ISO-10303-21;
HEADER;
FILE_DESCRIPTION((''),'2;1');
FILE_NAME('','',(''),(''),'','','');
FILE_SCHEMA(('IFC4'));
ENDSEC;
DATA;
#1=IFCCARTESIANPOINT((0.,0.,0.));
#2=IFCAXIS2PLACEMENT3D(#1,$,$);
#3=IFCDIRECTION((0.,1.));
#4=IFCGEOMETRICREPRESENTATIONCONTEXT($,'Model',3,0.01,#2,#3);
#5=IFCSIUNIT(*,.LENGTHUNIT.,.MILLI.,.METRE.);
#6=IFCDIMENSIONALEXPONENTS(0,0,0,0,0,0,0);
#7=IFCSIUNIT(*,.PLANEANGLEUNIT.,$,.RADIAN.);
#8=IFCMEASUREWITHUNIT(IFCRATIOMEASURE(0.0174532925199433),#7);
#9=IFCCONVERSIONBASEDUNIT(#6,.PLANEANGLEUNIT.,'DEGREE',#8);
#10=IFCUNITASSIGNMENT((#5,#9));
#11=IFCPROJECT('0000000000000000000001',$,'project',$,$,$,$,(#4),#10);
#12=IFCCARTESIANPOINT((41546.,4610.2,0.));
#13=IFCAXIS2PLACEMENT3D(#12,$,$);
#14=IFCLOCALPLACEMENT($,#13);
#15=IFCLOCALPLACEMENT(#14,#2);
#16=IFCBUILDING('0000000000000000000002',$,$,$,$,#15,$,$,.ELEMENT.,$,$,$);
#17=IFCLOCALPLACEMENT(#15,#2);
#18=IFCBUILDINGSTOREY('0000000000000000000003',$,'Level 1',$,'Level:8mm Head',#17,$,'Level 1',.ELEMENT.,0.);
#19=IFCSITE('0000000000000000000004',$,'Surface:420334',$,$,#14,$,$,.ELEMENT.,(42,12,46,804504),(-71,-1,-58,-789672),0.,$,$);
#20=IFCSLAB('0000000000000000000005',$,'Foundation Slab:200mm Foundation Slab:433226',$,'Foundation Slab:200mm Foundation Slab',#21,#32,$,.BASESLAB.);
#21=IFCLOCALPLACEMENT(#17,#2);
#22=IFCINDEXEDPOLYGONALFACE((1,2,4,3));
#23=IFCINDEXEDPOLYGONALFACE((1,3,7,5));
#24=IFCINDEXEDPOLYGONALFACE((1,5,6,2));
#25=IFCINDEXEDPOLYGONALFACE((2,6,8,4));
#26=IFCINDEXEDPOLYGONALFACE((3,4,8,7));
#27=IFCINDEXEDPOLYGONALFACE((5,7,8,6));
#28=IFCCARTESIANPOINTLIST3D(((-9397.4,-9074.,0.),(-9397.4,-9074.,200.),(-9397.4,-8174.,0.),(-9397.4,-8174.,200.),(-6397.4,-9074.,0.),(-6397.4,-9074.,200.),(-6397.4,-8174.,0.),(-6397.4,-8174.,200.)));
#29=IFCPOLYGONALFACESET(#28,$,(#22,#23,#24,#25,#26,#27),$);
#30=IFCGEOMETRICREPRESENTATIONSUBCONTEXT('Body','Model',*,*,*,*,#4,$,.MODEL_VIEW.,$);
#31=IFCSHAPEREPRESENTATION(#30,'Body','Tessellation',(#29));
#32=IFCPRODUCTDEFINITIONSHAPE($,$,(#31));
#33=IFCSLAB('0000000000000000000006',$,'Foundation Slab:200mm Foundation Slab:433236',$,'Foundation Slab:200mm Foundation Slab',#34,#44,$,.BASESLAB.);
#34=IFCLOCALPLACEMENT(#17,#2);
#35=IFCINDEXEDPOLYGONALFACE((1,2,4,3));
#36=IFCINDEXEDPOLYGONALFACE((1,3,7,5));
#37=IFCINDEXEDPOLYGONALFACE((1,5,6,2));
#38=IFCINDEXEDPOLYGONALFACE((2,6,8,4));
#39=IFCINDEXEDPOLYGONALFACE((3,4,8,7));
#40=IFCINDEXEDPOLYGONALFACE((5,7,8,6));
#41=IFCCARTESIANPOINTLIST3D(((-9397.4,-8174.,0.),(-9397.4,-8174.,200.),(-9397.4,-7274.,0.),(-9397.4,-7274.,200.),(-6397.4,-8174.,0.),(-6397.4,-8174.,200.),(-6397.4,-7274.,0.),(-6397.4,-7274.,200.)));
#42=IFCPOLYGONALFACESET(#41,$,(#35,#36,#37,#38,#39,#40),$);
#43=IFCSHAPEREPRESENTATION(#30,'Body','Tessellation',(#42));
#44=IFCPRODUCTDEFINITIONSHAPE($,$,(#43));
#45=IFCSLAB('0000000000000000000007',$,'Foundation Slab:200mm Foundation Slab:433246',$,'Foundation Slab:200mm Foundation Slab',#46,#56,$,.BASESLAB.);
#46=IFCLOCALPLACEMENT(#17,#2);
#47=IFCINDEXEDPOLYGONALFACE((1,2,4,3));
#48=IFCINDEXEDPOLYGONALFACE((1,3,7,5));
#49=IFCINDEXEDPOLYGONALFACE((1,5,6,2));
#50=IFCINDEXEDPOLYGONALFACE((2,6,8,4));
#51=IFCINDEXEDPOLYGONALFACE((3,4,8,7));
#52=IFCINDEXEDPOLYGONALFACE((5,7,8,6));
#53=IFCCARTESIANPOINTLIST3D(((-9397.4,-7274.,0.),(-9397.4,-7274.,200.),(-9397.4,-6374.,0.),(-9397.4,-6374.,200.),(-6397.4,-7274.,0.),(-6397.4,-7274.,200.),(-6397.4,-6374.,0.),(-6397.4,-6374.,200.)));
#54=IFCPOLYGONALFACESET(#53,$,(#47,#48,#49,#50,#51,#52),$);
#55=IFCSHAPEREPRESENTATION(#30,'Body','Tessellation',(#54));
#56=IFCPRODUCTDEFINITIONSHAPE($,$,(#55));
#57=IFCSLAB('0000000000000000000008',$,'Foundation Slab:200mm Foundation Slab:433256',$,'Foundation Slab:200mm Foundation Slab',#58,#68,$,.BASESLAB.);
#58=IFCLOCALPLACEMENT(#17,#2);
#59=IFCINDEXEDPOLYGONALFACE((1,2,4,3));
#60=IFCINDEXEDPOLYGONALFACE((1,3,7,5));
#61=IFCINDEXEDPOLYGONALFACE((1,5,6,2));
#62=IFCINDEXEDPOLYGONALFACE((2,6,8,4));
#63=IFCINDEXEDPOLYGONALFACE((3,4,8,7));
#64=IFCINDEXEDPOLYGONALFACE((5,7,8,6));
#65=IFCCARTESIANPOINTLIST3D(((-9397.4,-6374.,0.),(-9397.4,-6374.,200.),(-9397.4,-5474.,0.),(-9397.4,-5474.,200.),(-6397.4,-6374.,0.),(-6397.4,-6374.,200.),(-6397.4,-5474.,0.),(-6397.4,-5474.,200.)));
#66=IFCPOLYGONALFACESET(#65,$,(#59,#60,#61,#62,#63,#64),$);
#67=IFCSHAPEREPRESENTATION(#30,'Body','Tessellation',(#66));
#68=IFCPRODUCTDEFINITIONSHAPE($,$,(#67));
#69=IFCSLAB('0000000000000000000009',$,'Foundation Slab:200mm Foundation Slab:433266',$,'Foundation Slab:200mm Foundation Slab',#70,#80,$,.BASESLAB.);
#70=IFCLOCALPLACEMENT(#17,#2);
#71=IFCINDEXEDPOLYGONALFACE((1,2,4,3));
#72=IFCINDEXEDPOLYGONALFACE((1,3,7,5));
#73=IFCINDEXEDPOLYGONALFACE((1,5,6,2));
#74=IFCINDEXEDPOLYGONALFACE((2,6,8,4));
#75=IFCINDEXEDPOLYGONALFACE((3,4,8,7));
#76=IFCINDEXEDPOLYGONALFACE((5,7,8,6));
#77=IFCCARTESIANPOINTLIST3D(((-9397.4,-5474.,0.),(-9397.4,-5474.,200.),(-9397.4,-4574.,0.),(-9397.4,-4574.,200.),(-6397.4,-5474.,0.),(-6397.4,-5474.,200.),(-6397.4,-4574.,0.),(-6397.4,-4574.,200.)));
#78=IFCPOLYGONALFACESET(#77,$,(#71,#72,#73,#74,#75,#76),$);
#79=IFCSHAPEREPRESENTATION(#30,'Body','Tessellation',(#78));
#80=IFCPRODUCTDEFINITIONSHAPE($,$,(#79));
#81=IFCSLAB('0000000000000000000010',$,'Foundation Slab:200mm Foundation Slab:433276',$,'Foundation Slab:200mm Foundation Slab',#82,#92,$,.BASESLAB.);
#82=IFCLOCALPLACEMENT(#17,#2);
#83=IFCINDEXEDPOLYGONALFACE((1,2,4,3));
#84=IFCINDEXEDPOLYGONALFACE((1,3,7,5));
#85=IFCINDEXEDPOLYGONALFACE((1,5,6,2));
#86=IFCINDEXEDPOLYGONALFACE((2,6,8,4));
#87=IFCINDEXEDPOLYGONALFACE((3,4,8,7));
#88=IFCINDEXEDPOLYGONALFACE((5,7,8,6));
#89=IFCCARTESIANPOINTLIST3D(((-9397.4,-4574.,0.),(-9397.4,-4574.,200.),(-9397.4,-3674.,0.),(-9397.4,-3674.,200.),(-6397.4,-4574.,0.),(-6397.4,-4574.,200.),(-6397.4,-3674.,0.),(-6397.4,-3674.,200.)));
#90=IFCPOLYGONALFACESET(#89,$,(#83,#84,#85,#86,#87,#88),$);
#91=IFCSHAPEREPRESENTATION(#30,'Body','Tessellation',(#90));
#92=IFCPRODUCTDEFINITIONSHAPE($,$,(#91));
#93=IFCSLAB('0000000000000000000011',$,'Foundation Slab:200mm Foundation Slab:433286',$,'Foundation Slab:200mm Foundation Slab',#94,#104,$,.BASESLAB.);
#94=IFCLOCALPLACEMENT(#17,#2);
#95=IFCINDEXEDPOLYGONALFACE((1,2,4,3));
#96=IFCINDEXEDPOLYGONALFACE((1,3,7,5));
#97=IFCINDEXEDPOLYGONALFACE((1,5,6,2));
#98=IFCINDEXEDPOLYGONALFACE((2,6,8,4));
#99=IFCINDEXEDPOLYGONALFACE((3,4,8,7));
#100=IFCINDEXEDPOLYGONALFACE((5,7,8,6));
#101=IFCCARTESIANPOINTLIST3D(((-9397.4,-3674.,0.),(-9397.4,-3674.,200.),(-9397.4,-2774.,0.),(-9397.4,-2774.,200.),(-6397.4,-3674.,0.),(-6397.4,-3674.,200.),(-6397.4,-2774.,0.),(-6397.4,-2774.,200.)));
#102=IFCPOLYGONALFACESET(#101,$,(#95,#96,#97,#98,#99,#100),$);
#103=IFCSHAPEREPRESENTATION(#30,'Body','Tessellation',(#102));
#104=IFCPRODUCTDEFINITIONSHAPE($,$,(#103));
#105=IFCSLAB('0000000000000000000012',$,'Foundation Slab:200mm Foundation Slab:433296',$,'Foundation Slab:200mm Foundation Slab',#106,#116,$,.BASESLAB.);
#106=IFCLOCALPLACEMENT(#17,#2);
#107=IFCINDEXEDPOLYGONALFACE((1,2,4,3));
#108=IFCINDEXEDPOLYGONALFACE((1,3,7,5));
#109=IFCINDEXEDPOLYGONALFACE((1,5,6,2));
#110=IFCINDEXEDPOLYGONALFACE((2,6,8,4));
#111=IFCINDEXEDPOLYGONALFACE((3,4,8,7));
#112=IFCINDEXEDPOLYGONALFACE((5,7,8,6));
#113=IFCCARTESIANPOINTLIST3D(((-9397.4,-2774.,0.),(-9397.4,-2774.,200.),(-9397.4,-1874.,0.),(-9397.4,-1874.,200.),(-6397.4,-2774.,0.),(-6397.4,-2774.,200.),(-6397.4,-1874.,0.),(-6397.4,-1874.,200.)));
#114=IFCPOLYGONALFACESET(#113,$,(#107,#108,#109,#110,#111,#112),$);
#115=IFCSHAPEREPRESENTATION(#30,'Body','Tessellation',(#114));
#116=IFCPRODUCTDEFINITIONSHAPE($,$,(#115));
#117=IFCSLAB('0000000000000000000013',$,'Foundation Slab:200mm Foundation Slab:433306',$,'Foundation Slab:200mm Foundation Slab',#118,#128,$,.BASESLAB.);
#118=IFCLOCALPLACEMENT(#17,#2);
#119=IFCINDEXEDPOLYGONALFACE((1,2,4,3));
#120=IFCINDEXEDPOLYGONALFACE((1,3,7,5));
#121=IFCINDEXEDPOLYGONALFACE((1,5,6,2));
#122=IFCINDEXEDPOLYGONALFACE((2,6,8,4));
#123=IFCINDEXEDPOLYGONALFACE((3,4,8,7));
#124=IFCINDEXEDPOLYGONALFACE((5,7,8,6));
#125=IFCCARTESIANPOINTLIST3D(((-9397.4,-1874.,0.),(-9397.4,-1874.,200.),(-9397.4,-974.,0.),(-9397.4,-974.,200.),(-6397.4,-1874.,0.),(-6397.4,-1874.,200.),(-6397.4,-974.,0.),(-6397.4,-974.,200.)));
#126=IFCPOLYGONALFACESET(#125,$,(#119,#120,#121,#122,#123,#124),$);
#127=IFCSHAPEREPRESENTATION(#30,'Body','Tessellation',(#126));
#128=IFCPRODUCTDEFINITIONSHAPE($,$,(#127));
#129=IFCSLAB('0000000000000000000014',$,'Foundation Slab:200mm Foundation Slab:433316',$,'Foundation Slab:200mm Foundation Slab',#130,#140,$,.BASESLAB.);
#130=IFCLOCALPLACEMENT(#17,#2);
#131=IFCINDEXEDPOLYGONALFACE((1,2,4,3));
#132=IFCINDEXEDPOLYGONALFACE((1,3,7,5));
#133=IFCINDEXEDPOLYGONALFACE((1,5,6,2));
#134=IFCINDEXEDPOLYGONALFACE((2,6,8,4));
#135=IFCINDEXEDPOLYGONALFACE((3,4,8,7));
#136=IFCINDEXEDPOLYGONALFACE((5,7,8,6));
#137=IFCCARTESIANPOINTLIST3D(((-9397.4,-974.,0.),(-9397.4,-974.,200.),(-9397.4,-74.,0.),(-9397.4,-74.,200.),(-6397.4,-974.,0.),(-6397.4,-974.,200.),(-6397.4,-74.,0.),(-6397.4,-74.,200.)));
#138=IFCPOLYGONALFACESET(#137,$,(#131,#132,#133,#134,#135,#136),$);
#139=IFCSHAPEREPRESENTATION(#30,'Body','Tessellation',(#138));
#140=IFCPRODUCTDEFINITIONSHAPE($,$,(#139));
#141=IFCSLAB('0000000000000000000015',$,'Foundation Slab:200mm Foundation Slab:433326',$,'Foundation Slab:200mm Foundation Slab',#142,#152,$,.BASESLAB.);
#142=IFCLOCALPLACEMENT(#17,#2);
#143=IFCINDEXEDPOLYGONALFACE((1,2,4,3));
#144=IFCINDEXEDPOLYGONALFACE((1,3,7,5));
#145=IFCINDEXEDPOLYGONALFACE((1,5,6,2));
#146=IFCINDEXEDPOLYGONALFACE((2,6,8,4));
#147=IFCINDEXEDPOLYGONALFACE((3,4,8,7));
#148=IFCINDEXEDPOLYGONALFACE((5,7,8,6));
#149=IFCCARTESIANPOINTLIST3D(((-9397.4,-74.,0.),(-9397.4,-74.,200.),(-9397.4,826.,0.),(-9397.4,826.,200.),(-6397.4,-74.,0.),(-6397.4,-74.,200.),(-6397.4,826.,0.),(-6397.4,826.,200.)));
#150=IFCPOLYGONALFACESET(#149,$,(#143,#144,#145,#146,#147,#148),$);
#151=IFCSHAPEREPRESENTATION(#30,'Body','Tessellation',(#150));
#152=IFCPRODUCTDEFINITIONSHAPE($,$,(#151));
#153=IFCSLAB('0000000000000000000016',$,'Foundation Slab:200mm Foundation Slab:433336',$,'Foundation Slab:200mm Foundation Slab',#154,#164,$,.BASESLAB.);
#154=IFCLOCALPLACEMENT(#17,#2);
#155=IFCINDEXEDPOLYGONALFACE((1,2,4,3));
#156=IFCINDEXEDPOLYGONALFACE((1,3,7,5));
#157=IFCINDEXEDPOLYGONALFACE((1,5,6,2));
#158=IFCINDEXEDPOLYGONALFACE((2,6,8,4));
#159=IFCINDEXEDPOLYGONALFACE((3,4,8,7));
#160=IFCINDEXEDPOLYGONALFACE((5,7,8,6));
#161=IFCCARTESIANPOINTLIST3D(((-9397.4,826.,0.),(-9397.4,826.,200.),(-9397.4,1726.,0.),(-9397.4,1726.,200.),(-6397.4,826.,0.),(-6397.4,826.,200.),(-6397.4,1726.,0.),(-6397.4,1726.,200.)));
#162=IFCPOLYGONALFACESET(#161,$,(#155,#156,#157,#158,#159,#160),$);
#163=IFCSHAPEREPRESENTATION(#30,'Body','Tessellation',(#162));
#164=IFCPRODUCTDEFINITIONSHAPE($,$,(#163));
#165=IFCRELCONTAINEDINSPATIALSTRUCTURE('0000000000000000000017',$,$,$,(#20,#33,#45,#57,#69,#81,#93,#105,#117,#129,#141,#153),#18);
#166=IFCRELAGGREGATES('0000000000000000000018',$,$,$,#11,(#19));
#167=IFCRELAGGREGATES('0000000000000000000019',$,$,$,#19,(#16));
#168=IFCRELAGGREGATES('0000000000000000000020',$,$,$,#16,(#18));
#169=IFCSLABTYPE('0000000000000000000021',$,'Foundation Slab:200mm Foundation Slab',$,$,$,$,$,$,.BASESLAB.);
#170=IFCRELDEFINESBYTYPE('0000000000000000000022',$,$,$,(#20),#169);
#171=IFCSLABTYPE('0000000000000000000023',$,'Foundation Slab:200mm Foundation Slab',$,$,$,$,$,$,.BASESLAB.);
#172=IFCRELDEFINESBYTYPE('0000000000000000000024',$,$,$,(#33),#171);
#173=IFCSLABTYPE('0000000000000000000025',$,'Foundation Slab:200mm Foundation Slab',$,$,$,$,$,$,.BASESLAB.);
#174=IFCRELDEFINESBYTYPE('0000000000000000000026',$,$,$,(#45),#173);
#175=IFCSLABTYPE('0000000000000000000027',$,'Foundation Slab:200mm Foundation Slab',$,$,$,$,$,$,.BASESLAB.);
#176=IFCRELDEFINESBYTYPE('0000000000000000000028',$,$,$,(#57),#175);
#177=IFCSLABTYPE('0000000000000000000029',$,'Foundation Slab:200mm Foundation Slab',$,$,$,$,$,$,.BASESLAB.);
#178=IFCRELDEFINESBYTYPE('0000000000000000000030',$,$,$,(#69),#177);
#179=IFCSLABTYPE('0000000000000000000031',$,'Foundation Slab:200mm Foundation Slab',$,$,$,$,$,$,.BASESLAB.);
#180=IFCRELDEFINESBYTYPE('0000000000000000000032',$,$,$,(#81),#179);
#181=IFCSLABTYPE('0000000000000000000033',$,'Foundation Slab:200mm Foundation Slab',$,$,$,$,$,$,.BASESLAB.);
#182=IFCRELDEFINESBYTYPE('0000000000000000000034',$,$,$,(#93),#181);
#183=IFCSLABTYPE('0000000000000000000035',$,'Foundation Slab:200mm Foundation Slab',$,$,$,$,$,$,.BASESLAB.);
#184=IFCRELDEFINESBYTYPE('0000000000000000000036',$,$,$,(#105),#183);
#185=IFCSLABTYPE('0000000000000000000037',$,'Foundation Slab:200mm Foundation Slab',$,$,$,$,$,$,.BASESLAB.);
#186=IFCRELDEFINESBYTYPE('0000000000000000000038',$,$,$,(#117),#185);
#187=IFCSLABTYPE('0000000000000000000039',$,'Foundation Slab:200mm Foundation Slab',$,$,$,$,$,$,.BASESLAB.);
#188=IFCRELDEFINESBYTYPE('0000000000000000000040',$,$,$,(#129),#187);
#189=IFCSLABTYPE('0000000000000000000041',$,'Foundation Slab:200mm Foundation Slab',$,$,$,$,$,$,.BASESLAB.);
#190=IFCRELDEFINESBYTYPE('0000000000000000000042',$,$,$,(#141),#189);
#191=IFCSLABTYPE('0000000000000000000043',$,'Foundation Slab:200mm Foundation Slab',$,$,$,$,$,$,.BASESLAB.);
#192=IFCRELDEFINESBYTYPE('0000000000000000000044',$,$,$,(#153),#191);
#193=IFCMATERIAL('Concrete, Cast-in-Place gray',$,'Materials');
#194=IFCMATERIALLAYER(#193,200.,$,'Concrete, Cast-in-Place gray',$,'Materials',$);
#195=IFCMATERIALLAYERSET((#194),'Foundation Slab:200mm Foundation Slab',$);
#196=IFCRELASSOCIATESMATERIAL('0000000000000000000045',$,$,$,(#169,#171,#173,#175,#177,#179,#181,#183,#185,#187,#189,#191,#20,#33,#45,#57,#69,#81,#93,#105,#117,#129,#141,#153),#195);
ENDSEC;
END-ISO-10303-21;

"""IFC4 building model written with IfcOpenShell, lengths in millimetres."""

from ifc_helpers import new_model, entity, si_unit, converted_unit, direction, frame, frame_2d, origin, place, context, subcontext, project, spatial, rectangle, extrude, material, layer, layer_set, layer_usage, type_object, element, save


model = new_model("IFC4")

# Units and contexts
model_context = context("Model", 3, precision=0.01, world=origin(), true_north=direction((0.0, 1.0)))
body_context = subcontext(model_context, "Body", "Model", "MODEL_VIEW")
ifc_project = project(units=[si_unit("LENGTHUNIT", "METRE", prefix="MILLI"), converted_unit("PLANEANGLEUNIT", "DEGREE", entity("IfcRatioMeasure", 0.0174532925199433), si_unit("PLANEANGLEUNIT", "RADIAN"), dimensions=[0, 0, 0, 0, 0, 0, 0])], contexts=[model_context])

# Site, building, storey
site_placement = place(None, frame((41546.0, 4610.2, 0.0)))
site = spatial("IfcSite", under=ifc_project, at=site_placement, Name="Surface:420334", CompositionType="ELEMENT", RefLatitude=(42, 12, 46, 804504), RefLongitude=(-71, -1, -58, -789672), RefElevation=0.0)
building_placement = place(site_placement, origin())
building = spatial("IfcBuilding", under=site, at=building_placement, CompositionType="ELEMENT")
storey_placement = place(building_placement, origin())
storey = spatial("IfcBuildingStorey", under=building, at=storey_placement, Name="Level 1", ObjectType="Level:8mm Head", LongName="Level 1", CompositionType="ELEMENT", Elevation=0.0)

# Slabs
ifc_material = material(Name="Concrete, Cast-in-Place gray", Category="Materials")
ifc_layer = layer(ifc_material, 200.0, Name="Concrete, Cast-in-Place gray", Category="Materials")
ifc_layer_set = layer_set([ifc_layer], Name="Foundation Slab:200mm Foundation Slab")
ifc_layer_usage_1 = layer_usage(ifc_layer_set, "AXIS3", "POSITIVE", 0.0)
slab_type_1 = type_object("IfcSlabType", Name="Foundation Slab:200mm Foundation Slab", PredefinedType="BASESLAB", material=ifc_layer_set)
slab_1_placement = place(storey_placement, origin())
element("IfcSlab", 1, at=slab_1_placement, inside=storey, type_object=slab_type_1, material=ifc_layer_usage_1, Name="Foundation Slab:200mm Foundation Slab:433226", ObjectType="Foundation Slab:200mm Foundation Slab", PredefinedType="BASESLAB", context=body_context, shape_type="SweptSolid", body=[
    extrude(rectangle(XDim=900.0, YDim=3000.0, at=frame_2d((0.0, 0.0), x_axis=(1.0, 0.0))), frame((-7897.4, -8624.0, 200.0), z_axis=(0.0, 0.0, -1.0), x_axis=(0.0, 1.0, 0.0)), (0.0, 0.0, 1.0), 200.0),
])
ifc_layer_usage_2 = layer_usage(ifc_layer_set, "AXIS3", "POSITIVE", 0.0)
slab_type_2 = type_object("IfcSlabType", Name="Foundation Slab:200mm Foundation Slab", PredefinedType="BASESLAB", material=ifc_layer_set)
slab_2_placement = place(storey_placement, origin())
element("IfcSlab", 2, at=slab_2_placement, inside=storey, type_object=slab_type_2, material=ifc_layer_usage_2, Name="Foundation Slab:200mm Foundation Slab:433236", ObjectType="Foundation Slab:200mm Foundation Slab", PredefinedType="BASESLAB", context=body_context, shape_type="SweptSolid", body=[
    extrude(rectangle(XDim=900.0, YDim=3000.0, at=frame_2d((0.0, 0.0), x_axis=(1.0, 0.0))), frame((-7897.4, -7724.0, 200.0), z_axis=(0.0, 0.0, -1.0), x_axis=(0.0, 1.0, 0.0)), (0.0, 0.0, 1.0), 200.0),
])
ifc_layer_usage_3 = layer_usage(ifc_layer_set, "AXIS3", "POSITIVE", 0.0)
slab_type_3 = type_object("IfcSlabType", Name="Foundation Slab:200mm Foundation Slab", PredefinedType="BASESLAB", material=ifc_layer_set)
slab_3_placement = place(storey_placement, origin())
element("IfcSlab", 3, at=slab_3_placement, inside=storey, type_object=slab_type_3, material=ifc_layer_usage_3, Name="Foundation Slab:200mm Foundation Slab:433246", ObjectType="Foundation Slab:200mm Foundation Slab", PredefinedType="BASESLAB", context=body_context, shape_type="SweptSolid", body=[
    extrude(rectangle(XDim=900.0, YDim=3000.0, at=frame_2d((0.0, 0.0), x_axis=(1.0, 0.0))), frame((-7897.4, -6824.0, 200.0), z_axis=(0.0, 0.0, -1.0), x_axis=(0.0, 1.0, 0.0)), (0.0, 0.0, 1.0), 200.0),
])
ifc_layer_usage_4 = layer_usage(ifc_layer_set, "AXIS3", "POSITIVE", 0.0)
slab_type_4 = type_object("IfcSlabType", Name="Foundation Slab:200mm Foundation Slab", PredefinedType="BASESLAB", material=ifc_layer_set)
slab_4_placement = place(storey_placement, origin())
element("IfcSlab", 4, at=slab_4_placement, inside=storey, type_object=slab_type_4, material=ifc_layer_usage_4, Name="Foundation Slab:200mm Foundation Slab:433256", ObjectType="Foundation Slab:200mm Foundation Slab", PredefinedType="BASESLAB", context=body_context, shape_type="SweptSolid", body=[
    extrude(rectangle(XDim=900.0, YDim=3000.0, at=frame_2d((0.0, 0.0), x_axis=(1.0, 0.0))), frame((-7897.4, -5924.0, 200.0), z_axis=(0.0, 0.0, -1.0), x_axis=(0.0, 1.0, 0.0)), (0.0, 0.0, 1.0), 200.0),
])
ifc_layer_usage_5 = layer_usage(ifc_layer_set, "AXIS3", "POSITIVE", 0.0)
slab_type_5 = type_object("IfcSlabType", Name="Foundation Slab:200mm Foundation Slab", PredefinedType="BASESLAB", material=ifc_layer_set)
slab_5_placement = place(storey_placement, origin())
element("IfcSlab", 5, at=slab_5_placement, inside=storey, type_object=slab_type_5, material=ifc_layer_usage_5, Name="Foundation Slab:200mm Foundation Slab:433266", ObjectType="Foundation Slab:200mm Foundation Slab", PredefinedType="BASESLAB", context=body_context, shape_type="SweptSolid", body=[
    extrude(rectangle(XDim=900.0, YDim=3000.0, at=frame_2d((0.0, 0.0), x_axis=(1.0, 0.0))), frame((-7897.4, -5024.0, 200.0), z_axis=(0.0, 0.0, -1.0), x_axis=(0.0, 1.0, 0.0)), (0.0, 0.0, 1.0), 200.0),
])
ifc_layer_usage_6 = layer_usage(ifc_layer_set, "AXIS3", "POSITIVE", 0.0)
slab_type_6 = type_object("IfcSlabType", Name="Foundation Slab:200mm Foundation Slab", PredefinedType="BASESLAB", material=ifc_layer_set)
slab_6_placement = place(storey_placement, origin())
element("IfcSlab", 6, at=slab_6_placement, inside=storey, type_object=slab_type_6, material=ifc_layer_usage_6, Name="Foundation Slab:200mm Foundation Slab:433276", ObjectType="Foundation Slab:200mm Foundation Slab", PredefinedType="BASESLAB", context=body_context, shape_type="SweptSolid", body=[
    extrude(rectangle(XDim=900.0, YDim=3000.0, at=frame_2d((0.0, 0.0), x_axis=(1.0, 0.0))), frame((-7897.4, -4124.0, 200.0), z_axis=(0.0, 0.0, -1.0), x_axis=(0.0, 1.0, 0.0)), (0.0, 0.0, 1.0), 200.0),
])
ifc_layer_usage_7 = layer_usage(ifc_layer_set, "AXIS3", "POSITIVE", 0.0)
slab_type_7 = type_object("IfcSlabType", Name="Foundation Slab:200mm Foundation Slab", PredefinedType="BASESLAB", material=ifc_layer_set)
slab_7_placement = place(storey_placement, origin())
element("IfcSlab", 7, at=slab_7_placement, inside=storey, type_object=slab_type_7, material=ifc_layer_usage_7, Name="Foundation Slab:200mm Foundation Slab:433286", ObjectType="Foundation Slab:200mm Foundation Slab", PredefinedType="BASESLAB", context=body_context, shape_type="SweptSolid", body=[
    extrude(rectangle(XDim=900.0, YDim=3000.0, at=frame_2d((0.0, 0.0), x_axis=(1.0, 0.0))), frame((-7897.4, -3224.0, 200.0), z_axis=(0.0, 0.0, -1.0), x_axis=(0.0, 1.0, 0.0)), (0.0, 0.0, 1.0), 200.0),
])
ifc_layer_usage_8 = layer_usage(ifc_layer_set, "AXIS3", "POSITIVE", 0.0)
slab_type_8 = type_object("IfcSlabType", Name="Foundation Slab:200mm Foundation Slab", PredefinedType="BASESLAB", material=ifc_layer_set)
slab_8_placement = place(storey_placement, origin())
element("IfcSlab", 8, at=slab_8_placement, inside=storey, type_object=slab_type_8, material=ifc_layer_usage_8, Name="Foundation Slab:200mm Foundation Slab:433296", ObjectType="Foundation Slab:200mm Foundation Slab", PredefinedType="BASESLAB", context=body_context, shape_type="SweptSolid", body=[
    extrude(rectangle(XDim=900.0, YDim=3000.0, at=frame_2d((0.0, 0.0), x_axis=(1.0, 0.0))), frame((-7897.4, -2324.0, 200.0), z_axis=(0.0, 0.0, -1.0), x_axis=(0.0, 1.0, 0.0)), (0.0, 0.0, 1.0), 200.0),
])
ifc_layer_usage_9 = layer_usage(ifc_layer_set, "AXIS3", "POSITIVE", 0.0)
slab_type_9 = type_object("IfcSlabType", Name="Foundation Slab:200mm Foundation Slab", PredefinedType="BASESLAB", material=ifc_layer_set)
slab_9_placement = place(storey_placement, origin())
element("IfcSlab", 9, at=slab_9_placement, inside=storey, type_object=slab_type_9, material=ifc_layer_usage_9, Name="Foundation Slab:200mm Foundation Slab:433306", ObjectType="Foundation Slab:200mm Foundation Slab", PredefinedType="BASESLAB", context=body_context, shape_type="SweptSolid", body=[
    extrude(rectangle(XDim=900.0, YDim=3000.0, at=frame_2d((0.0, 0.0), x_axis=(1.0, 0.0))), frame((-7897.4, -1424.0, 200.0), z_axis=(0.0, 0.0, -1.0), x_axis=(0.0, 1.0, 0.0)), (0.0, 0.0, 1.0), 200.0),
])
ifc_layer_usage_10 = layer_usage(ifc_layer_set, "AXIS3", "POSITIVE", 0.0)
slab_type_10 = type_object("IfcSlabType", Name="Foundation Slab:200mm Foundation Slab", PredefinedType="BASESLAB", material=ifc_layer_set)
slab_10_placement = place(storey_placement, origin())
element("IfcSlab", 10, at=slab_10_placement, inside=storey, type_object=slab_type_10, material=ifc_layer_usage_10, Name="Foundation Slab:200mm Foundation Slab:433316", ObjectType="Foundation Slab:200mm Foundation Slab", PredefinedType="BASESLAB", context=body_context, shape_type="SweptSolid", body=[
    extrude(rectangle(XDim=900.0, YDim=3000.0, at=frame_2d((0.0, 0.0), x_axis=(1.0, 0.0))), frame((-7897.4, -524.0, 200.0), z_axis=(0.0, 0.0, -1.0), x_axis=(0.0, 1.0, 0.0)), (0.0, 0.0, 1.0), 200.0),
])
ifc_layer_usage_11 = layer_usage(ifc_layer_set, "AXIS3", "POSITIVE", 0.0)
slab_type_11 = type_object("IfcSlabType", Name="Foundation Slab:200mm Foundation Slab", PredefinedType="BASESLAB", material=ifc_layer_set)
slab_11_placement = place(storey_placement, origin())
element("IfcSlab", 11, at=slab_11_placement, inside=storey, type_object=slab_type_11, material=ifc_layer_usage_11, Name="Foundation Slab:200mm Foundation Slab:433326", ObjectType="Foundation Slab:200mm Foundation Slab", PredefinedType="BASESLAB", context=body_context, shape_type="SweptSolid", body=[
    extrude(rectangle(XDim=900.0, YDim=3000.0, at=frame_2d((0.0, 0.0), x_axis=(1.0, 0.0))), frame((-7897.4, 376.0, 200.0), z_axis=(0.0, 0.0, -1.0), x_axis=(0.0, 1.0, 0.0)), (0.0, 0.0, 1.0), 200.0),
])
ifc_layer_usage_12 = layer_usage(ifc_layer_set, "AXIS3", "POSITIVE", 0.0)
slab_type_12 = type_object("IfcSlabType", Name="Foundation Slab:200mm Foundation Slab", PredefinedType="BASESLAB", material=ifc_layer_set)
slab_12_placement = place(storey_placement, origin())
element("IfcSlab", 12, at=slab_12_placement, inside=storey, type_object=slab_type_12, material=ifc_layer_usage_12, Name="Foundation Slab:200mm Foundation Slab:433336", ObjectType="Foundation Slab:200mm Foundation Slab", PredefinedType="BASESLAB", context=body_context, shape_type="SweptSolid", body=[
    extrude(rectangle(XDim=900.0, YDim=3000.0, at=frame_2d((0.0, 0.0), x_axis=(1.0, 0.0))), frame((-7897.4, 1276.0, 200.0), z_axis=(0.0, 0.0, -1.0), x_axis=(0.0, 1.0, 0.0)), (0.0, 0.0, 1.0), 200.0),
])

save(model, "model.ifc")
